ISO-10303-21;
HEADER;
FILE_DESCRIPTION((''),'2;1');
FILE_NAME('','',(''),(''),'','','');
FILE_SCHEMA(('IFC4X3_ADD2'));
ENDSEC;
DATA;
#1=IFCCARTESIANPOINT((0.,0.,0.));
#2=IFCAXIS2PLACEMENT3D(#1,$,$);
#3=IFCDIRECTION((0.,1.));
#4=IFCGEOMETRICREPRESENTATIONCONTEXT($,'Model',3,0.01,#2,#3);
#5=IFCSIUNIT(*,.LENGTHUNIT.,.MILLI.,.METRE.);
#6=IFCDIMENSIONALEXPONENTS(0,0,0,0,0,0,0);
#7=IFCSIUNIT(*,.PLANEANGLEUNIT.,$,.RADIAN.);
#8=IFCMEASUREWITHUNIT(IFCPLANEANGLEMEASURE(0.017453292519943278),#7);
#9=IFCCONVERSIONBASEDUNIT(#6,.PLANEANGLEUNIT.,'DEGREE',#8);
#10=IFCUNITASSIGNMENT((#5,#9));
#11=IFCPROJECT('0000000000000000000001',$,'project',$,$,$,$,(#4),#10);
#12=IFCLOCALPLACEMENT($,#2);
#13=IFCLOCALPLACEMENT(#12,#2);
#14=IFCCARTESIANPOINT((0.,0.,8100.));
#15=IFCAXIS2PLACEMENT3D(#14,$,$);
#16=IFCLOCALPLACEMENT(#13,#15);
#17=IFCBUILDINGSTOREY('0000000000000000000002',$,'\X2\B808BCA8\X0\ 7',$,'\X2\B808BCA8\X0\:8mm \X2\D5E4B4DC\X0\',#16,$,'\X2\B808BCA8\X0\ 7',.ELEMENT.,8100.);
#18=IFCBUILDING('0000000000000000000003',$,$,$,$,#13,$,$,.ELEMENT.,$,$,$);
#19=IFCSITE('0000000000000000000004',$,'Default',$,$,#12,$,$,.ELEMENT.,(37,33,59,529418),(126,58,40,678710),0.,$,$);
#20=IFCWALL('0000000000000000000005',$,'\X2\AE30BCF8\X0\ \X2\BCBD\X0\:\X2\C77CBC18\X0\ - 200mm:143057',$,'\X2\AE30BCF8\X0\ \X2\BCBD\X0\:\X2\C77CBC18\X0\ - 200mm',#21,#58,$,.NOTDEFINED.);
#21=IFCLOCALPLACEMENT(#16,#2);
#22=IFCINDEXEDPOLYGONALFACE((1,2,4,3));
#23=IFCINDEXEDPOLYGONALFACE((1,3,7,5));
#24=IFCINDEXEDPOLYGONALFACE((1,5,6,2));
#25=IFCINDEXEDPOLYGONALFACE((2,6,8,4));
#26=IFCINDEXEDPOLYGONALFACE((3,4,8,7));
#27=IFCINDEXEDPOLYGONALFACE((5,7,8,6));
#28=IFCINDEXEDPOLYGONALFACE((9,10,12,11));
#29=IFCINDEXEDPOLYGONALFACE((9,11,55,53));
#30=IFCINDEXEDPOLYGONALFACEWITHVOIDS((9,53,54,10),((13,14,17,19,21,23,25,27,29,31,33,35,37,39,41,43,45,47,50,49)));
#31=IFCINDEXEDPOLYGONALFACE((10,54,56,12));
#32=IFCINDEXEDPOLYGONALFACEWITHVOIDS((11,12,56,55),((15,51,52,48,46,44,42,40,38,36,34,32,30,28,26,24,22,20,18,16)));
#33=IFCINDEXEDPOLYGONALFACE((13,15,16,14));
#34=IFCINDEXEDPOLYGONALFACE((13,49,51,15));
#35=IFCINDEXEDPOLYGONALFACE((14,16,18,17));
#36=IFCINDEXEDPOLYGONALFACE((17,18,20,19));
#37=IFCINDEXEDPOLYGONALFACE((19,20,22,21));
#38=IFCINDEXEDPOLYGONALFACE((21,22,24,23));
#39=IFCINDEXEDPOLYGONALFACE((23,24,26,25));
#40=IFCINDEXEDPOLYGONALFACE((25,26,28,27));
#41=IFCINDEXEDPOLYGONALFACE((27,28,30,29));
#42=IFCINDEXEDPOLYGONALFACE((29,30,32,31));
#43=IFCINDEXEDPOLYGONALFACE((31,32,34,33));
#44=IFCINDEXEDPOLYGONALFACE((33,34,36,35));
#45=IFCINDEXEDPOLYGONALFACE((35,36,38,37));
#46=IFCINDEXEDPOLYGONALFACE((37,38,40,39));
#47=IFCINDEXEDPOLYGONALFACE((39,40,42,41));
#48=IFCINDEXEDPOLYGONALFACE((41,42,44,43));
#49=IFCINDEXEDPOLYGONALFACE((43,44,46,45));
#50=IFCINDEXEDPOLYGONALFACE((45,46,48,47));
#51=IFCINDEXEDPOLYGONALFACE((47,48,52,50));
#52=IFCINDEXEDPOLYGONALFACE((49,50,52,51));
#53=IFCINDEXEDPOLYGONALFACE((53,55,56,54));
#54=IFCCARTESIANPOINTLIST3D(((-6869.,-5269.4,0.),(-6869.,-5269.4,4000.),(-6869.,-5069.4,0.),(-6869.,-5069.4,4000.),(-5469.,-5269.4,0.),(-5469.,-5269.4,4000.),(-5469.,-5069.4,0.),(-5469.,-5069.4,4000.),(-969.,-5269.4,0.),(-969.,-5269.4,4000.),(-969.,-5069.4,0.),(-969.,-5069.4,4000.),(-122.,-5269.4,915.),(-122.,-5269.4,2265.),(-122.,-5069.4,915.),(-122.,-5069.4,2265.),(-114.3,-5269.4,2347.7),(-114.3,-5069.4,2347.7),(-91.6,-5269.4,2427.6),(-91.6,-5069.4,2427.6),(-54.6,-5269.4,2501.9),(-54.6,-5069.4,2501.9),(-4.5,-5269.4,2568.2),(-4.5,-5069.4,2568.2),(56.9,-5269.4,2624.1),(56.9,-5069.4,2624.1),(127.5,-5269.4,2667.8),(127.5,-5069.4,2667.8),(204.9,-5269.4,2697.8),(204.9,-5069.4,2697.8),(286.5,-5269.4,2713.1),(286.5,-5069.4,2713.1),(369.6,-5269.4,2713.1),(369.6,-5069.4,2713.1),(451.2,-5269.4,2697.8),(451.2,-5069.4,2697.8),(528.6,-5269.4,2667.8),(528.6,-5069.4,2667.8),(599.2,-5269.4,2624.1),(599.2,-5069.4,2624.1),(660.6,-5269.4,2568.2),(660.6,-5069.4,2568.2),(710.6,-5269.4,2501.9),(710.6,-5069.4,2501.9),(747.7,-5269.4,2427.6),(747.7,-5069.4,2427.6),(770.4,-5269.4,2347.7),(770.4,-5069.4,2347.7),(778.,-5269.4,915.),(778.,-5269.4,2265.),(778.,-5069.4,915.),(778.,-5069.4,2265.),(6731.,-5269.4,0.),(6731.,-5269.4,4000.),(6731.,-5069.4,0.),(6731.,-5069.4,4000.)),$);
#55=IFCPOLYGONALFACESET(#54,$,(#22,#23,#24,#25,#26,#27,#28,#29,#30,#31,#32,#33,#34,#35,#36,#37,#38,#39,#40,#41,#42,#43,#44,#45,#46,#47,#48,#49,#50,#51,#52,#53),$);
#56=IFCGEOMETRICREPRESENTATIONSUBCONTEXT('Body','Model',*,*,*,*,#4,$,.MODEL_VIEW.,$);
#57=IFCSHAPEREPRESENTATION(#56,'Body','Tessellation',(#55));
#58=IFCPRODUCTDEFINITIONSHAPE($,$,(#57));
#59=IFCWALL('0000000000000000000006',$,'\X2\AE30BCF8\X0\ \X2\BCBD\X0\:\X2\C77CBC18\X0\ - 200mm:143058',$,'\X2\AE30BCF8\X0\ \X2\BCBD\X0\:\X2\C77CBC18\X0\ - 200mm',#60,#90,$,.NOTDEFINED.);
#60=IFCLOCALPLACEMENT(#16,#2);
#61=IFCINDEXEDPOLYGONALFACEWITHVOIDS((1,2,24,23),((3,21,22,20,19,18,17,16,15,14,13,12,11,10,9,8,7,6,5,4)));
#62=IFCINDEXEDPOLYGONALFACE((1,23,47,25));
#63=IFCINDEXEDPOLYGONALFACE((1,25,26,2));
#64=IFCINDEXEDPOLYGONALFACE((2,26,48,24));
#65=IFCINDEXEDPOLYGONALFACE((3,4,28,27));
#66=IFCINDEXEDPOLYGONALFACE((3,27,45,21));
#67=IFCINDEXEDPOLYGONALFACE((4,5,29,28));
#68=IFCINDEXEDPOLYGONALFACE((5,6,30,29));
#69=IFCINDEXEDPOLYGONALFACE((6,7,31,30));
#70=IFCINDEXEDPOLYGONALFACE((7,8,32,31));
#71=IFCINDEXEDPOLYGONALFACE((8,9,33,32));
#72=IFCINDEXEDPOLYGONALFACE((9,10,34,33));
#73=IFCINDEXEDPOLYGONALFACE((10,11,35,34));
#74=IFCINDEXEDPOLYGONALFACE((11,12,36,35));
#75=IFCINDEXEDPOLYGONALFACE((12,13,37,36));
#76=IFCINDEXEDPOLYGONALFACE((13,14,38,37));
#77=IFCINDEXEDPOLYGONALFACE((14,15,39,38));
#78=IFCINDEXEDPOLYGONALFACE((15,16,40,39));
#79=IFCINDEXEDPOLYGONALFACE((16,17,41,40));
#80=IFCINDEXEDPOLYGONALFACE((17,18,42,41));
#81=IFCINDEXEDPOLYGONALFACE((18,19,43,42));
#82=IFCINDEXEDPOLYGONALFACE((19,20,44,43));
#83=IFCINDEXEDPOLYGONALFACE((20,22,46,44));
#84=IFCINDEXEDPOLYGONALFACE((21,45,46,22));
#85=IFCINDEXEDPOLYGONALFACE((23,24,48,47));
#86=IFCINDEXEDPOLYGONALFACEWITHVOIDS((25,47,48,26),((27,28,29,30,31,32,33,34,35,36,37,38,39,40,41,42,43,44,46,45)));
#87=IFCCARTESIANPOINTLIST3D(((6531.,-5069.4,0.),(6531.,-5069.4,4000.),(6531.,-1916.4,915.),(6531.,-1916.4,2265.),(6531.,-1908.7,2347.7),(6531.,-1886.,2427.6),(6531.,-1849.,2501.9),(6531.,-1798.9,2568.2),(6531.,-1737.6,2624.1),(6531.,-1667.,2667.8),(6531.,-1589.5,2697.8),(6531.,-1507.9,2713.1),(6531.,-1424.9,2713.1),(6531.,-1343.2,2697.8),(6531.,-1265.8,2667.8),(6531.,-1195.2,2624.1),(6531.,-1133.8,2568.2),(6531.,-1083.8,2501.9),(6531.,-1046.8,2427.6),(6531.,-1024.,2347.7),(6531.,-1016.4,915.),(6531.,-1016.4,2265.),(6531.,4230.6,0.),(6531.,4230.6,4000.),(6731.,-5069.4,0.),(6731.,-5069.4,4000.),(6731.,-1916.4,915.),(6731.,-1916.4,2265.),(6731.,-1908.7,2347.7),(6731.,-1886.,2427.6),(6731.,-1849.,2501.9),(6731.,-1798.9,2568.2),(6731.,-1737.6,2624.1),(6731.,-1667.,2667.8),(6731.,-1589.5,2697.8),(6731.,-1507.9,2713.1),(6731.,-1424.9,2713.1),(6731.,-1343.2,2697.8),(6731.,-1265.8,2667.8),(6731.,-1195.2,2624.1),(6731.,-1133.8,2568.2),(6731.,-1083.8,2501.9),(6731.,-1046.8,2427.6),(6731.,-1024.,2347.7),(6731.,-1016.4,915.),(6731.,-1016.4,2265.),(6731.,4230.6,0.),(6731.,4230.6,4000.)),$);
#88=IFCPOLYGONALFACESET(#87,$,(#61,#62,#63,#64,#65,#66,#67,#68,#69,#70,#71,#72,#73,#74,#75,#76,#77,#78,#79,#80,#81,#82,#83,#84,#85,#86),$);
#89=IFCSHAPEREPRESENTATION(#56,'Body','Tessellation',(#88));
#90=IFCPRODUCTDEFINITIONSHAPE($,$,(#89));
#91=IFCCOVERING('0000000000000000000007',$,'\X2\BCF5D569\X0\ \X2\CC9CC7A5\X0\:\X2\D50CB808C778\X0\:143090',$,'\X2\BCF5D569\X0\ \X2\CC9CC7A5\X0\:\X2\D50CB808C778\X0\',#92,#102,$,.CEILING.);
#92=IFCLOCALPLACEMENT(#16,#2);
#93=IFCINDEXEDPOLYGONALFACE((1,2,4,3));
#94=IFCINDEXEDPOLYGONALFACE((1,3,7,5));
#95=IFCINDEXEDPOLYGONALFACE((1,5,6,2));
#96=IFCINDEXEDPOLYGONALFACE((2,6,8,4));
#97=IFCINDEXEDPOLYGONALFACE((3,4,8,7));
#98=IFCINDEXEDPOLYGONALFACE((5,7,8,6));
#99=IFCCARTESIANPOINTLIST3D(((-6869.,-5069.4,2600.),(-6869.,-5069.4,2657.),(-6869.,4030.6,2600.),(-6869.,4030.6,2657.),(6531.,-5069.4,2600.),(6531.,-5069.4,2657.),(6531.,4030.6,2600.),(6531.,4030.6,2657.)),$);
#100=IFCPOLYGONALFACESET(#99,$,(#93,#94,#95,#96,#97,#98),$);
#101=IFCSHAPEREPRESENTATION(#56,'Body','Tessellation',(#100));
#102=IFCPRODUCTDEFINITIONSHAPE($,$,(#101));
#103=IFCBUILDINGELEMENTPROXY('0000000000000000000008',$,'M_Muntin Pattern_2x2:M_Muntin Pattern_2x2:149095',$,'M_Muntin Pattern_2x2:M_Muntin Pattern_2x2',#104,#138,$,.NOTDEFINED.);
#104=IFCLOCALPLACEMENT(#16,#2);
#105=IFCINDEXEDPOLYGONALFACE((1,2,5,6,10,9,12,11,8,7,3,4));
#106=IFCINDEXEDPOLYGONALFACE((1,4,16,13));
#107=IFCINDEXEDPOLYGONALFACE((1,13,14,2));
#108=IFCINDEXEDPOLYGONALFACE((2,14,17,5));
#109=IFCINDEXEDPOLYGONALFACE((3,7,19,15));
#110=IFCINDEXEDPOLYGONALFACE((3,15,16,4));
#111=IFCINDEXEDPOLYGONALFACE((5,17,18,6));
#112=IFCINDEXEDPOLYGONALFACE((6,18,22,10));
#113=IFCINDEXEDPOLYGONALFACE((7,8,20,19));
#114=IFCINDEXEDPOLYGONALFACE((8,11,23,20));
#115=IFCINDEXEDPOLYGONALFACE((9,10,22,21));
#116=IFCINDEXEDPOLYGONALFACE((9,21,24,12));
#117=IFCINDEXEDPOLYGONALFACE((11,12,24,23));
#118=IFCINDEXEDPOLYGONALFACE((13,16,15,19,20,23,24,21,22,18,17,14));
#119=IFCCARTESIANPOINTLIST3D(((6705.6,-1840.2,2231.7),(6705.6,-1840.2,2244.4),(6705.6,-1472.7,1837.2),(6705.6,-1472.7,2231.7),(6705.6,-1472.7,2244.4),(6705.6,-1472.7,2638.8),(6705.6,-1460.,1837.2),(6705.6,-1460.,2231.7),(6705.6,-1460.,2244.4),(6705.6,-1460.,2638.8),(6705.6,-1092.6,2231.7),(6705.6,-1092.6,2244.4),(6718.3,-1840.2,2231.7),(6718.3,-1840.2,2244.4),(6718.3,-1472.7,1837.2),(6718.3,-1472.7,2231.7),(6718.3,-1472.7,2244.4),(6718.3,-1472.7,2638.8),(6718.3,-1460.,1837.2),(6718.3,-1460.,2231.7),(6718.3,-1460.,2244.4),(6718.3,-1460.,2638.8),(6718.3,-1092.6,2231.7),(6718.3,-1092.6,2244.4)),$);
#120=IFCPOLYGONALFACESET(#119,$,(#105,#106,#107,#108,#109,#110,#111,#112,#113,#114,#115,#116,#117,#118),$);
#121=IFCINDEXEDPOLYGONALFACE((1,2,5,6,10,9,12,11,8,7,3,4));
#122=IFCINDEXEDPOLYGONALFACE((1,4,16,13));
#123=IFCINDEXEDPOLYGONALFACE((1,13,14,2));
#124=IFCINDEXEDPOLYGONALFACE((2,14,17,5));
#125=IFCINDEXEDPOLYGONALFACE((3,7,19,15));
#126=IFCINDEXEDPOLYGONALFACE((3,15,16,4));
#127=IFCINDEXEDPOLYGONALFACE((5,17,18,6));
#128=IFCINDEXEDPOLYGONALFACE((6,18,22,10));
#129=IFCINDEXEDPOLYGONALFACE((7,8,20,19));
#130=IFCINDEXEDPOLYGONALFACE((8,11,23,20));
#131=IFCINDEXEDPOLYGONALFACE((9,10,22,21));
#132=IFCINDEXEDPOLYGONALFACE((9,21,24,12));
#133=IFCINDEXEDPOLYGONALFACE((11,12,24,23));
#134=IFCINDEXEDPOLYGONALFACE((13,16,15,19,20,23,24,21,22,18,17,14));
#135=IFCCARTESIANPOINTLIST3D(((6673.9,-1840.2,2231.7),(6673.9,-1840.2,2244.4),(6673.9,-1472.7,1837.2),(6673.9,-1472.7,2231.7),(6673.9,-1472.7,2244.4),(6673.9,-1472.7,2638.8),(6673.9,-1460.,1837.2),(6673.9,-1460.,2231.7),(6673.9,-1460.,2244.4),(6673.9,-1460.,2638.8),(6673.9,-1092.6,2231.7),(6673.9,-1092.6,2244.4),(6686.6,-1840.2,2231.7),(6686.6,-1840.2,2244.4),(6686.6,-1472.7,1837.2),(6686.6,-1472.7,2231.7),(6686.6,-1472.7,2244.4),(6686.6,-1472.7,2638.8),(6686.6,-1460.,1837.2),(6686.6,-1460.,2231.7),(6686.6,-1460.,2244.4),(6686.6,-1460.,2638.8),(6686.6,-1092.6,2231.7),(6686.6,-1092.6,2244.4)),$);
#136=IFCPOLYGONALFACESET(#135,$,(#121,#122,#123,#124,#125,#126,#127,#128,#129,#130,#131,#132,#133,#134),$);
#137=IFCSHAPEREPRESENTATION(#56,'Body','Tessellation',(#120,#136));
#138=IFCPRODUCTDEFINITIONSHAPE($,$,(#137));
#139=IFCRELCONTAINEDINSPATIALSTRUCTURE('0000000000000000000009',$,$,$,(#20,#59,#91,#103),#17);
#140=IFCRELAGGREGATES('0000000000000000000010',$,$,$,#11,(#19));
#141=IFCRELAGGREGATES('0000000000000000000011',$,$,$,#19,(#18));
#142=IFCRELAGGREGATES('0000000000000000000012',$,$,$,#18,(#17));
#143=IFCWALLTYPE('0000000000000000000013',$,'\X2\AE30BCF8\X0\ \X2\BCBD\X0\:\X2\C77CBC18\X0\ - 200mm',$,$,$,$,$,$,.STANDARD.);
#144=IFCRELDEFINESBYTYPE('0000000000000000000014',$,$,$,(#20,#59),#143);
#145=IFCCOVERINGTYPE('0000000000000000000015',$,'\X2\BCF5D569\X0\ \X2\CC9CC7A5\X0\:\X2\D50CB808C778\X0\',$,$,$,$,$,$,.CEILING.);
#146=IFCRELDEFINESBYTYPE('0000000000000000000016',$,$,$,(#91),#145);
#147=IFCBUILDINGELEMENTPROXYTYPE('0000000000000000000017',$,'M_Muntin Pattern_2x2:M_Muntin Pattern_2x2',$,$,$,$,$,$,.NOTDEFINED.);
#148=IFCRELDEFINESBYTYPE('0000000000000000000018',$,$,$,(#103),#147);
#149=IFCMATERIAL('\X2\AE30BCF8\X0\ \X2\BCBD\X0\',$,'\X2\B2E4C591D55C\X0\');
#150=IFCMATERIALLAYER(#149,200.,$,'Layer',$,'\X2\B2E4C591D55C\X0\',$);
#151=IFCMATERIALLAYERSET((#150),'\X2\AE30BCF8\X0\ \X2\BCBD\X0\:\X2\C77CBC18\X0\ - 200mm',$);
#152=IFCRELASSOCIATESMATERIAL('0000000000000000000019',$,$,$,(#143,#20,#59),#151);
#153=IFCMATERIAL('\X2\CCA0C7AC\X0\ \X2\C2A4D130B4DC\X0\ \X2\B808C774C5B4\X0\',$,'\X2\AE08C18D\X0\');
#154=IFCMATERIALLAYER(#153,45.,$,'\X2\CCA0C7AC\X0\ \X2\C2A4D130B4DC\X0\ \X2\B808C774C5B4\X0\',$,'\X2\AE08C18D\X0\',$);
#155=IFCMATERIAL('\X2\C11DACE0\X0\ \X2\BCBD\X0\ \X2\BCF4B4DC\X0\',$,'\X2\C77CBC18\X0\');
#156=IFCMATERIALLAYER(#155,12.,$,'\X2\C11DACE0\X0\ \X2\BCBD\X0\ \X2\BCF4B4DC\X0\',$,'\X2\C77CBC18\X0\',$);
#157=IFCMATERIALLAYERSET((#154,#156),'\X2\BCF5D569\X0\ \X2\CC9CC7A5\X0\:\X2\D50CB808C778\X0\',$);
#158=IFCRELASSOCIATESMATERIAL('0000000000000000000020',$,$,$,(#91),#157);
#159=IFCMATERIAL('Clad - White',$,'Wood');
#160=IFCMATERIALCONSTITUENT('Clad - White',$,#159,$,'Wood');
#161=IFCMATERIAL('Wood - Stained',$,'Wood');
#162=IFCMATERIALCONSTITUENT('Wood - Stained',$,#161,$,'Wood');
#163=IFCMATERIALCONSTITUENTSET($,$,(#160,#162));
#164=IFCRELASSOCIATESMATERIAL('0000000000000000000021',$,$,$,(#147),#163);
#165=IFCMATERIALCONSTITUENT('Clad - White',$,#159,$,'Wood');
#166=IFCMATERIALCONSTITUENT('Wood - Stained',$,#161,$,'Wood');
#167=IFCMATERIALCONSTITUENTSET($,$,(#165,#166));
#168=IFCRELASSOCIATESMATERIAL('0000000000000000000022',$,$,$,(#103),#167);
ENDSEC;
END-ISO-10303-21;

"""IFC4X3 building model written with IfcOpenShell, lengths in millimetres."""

from ifc_helpers import new_model, entity, si_unit, converted_unit, direction, frame, frame_2d, origin, origin_2d_with_axis, place, context, subcontext, project, spatial, polyline, circle_curve, parameter, trimmed, segment, composite_curve, rectangle, outline, extrude, source, transform, mapped, material, layer, layer_set, layer_usage, constituent, constituent_set, type_object, type_shapes, element, save


model = new_model("IFC4X3")

# Units and contexts
model_context = context("Model", 3, precision=0.01, world=origin(), true_north=direction((0.0, 1.0)))
body_context = subcontext(model_context, "Body", "Model", "MODEL_VIEW")
ifc_project = project(units=[si_unit("LENGTHUNIT", "METRE", prefix="MILLI"), converted_unit("PLANEANGLEUNIT", "DEGREE", entity("IfcPlaneAngleMeasure", 0.017453292519943278), si_unit("PLANEANGLEUNIT", "RADIAN"), dimensions=[0, 0, 0, 0, 0, 0, 0])], contexts=[model_context])

# Site, building, storey
site_placement = place(None, origin())
site = spatial("IfcSite", under=ifc_project, at=site_placement, Name="Default", CompositionType="ELEMENT", RefLatitude=(37, 33, 59, 529418), RefLongitude=(126, 58, 40, 678710), RefElevation=0.0)
building_placement = place(site_placement, origin())
building = spatial("IfcBuilding", under=site, at=building_placement, CompositionType="ELEMENT")
storey_placement = place(building_placement, frame((0.0, 0.0, 8100.0)))
storey = spatial("IfcBuildingStorey", under=building, at=storey_placement, Name="레벨 7", ObjectType="레벨:8mm 헤드", LongName="레벨 7", CompositionType="ELEMENT", Elevation=8100.0)

# Shared definitions
ifc_material_1 = material(Name="기본 벽", Category="다양한")
ifc_layer_1 = layer(ifc_material_1, 200.0, Name="Layer", Category="다양한")
ifc_layer_set_1 = layer_set([ifc_layer_1], Name="기본 벽:일반 - 200mm")
wall_type = type_object("IfcWallType", Name="기본 벽:일반 - 200mm", PredefinedType="STANDARD", material=ifc_layer_set_1)

# Wall, openings
wall_1_placement = place(storey_placement, frame((6731.0, -5169.4, 0.0), z_axis=(0.0, 0.0, 1.0), x_axis=(-1.0, 0.0, 0.0)))
wall_1 = element("IfcWall", 1, at=wall_1_placement, inside=storey, type_object=wall_type, material=ifc_layer_set_1, Name="기본 벽:일반 - 200mm:143057", ObjectType="기본 벽:일반 - 200mm", PredefinedType="NOTDEFINED", context=body_context, shape_type="SweptSolid", body=[
    extrude(rectangle(XDim=200.0, YDim=13600.0, at=frame_2d((6800.0, 0.0), x_axis=(0.0, -1.0))), origin(), (0.0, 0.0, 1.0), 4000.0),
])
opening_1_placement = place(wall_1_placement, frame((12200.0, 252.4, -8100.0)))
element("IfcOpeningElement", 2, at=opening_1_placement, cuts=wall_1, PredefinedType="OPENING", context=body_context, shape_type="SweptSolid", body=[
    extrude(rectangle(XDim=14356.3, YDim=4500.0, at=frame_2d((0.0, 0.0), x_axis=(0.0, 1.0))), frame((-2250.0, -504.8, 7178.2), z_axis=(0.0, 1.0, 0.0), x_axis=(-1.0, 0.0, 0.0)), (0.0, 0.0, 1.0), 504.8),
])
opening_2_placement = place(wall_1_placement, frame((5953.0, -100.0, 915.0)))
element("IfcOpeningElement", 3, at=opening_2_placement, cuts=wall_1, PredefinedType="OPENING", context=body_context, shape_type="SweptSolid", body=[
    extrude(outline(composite_curve([segment(polyline([(1350.0, 900.0), (0.0, 900.0)]), True, "CONTINUOUS"), segment(polyline([(0.0, 900.0), (0.0, 0.0)]), True, "CONTINUOUS"), segment(polyline([(0.0, 0.0), (1350.0, 0.0)]), True, "CONTINUOUS"), segment(trimmed(circle_curve(frame_2d((1350.0, 450.0), x_axis=(0.0, 1.0)), 450.0), [parameter(180.0)], [parameter(0.0)], True, "PARAMETER"), True, "CONTINUOUS")], self_intersect=False)), frame((0.0, 0.0, 0.0), z_axis=(0.0, 1.0, 0.0), x_axis=(0.0, 0.0, 1.0)), (0.0, 0.0, 1.0), 200.0),
])

# Wall, opening
wall_2_placement = place(storey_placement, frame((6631.0, 4230.6, 0.0), z_axis=(0.0, 0.0, 1.0), x_axis=(0.0, -1.0, 0.0)))
wall_2 = element("IfcWall", 4, at=wall_2_placement, inside=storey, type_object=wall_type, material=ifc_layer_set_1, Name="기본 벽:일반 - 200mm:143058", ObjectType="기본 벽:일반 - 200mm", PredefinedType="NOTDEFINED", context=body_context, shape_type="SweptSolid", body=[
    extrude(rectangle(XDim=9300.0, YDim=200.0, at=frame_2d((4650.0, 0.0), x_axis=(-1.0, 0.0))), origin(), (0.0, 0.0, 1.0), 4000.0),
])
opening_3_placement = place(wall_2_placement, frame((5247.0, -100.0, 915.0)))
element("IfcOpeningElement", 5, at=opening_3_placement, cuts=wall_2, PredefinedType="OPENING", context=body_context, shape_type="SweptSolid", body=[
    extrude(outline(composite_curve([segment(polyline([(1350.0, 900.0), (0.0, 900.0)]), True, "CONTINUOUS"), segment(polyline([(0.0, 900.0), (0.0, 0.0)]), True, "CONTINUOUS"), segment(polyline([(0.0, 0.0), (1350.0, 0.0)]), True, "CONTINUOUS"), segment(trimmed(circle_curve(frame_2d((1350.0, 450.0), x_axis=(0.0, 1.0)), 450.0), [parameter(180.0)], [parameter(0.0)], True, "PARAMETER"), True, "CONTINUOUS")], self_intersect=False)), frame((0.0, 0.0, 0.0), z_axis=(0.0, 1.0, 0.0), x_axis=(0.0, 0.0, 1.0)), (0.0, 0.0, 1.0), 200.0),
])

# Covering
ifc_material_2 = material(Name="철재 스터드 레이어", Category="금속")
ifc_layer_2 = layer(ifc_material_2, 45.0, Name="철재 스터드 레이어", Category="금속")
ifc_material_3 = material(Name="석고 벽 보드", Category="일반")
ifc_layer_3 = layer(ifc_material_3, 12.0, Name="석고 벽 보드", Category="일반")
ifc_layer_set_2 = layer_set([ifc_layer_2, ifc_layer_3], Name="복합 천장:플레인")
ifc_layer_usage_1 = layer_usage(ifc_layer_set_2, "AXIS3", "NEGATIVE", 0.0)
covering_type = type_object("IfcCoveringType", Name="복합 천장:플레인", PredefinedType="CEILING")
covering_placement = place(storey_placement, frame((-6869.0, -5069.4, 2600.0)))
element("IfcCovering", 6, at=covering_placement, inside=storey, type_object=covering_type, material=ifc_layer_usage_1, Name="복합 천장:플레인:143090", ObjectType="복합 천장:플레인", PredefinedType="CEILING", context=body_context, shape_type="SweptSolid", body=[
    extrude(rectangle(XDim=9100.0, YDim=13400.0, at=origin_2d_with_axis()), frame((6700.0, 4550.0, 0.0), z_axis=(0.0, 0.0, 1.0), x_axis=(0.0, -1.0, 0.0)), (0.0, 0.0, 1.0), 57.0),
])

# Building element proxy
ifc_material_4 = material(Name="Clad - White", Category="Wood")
ifc_constituent_1 = constituent(ifc_material_4, Name="Clad - White", Category="Wood")
ifc_material_5 = material(Name="Wood - Stained", Category="Wood")
ifc_constituent_2 = constituent(ifc_material_5, Name="Wood - Stained", Category="Wood")
ifc_constituent_set_1 = constituent_set(constituents=[ifc_constituent_1, ifc_constituent_2])
ifc_constituent_3 = constituent(ifc_material_4, Name="Clad - White", Category="Wood")
ifc_constituent_4 = constituent(ifc_material_5, Name="Wood - Stained", Category="Wood")
ifc_constituent_set_2 = constituent_set(constituents=[ifc_constituent_3, ifc_constituent_4])
building_element_proxy_type_1 = type_object("IfcBuildingElementProxyType", Name="M_Muntin Pattern_2x2:M_Muntin Pattern_2x2", PredefinedType="NOTDEFINED", material=ifc_constituent_set_2)
shared_shape_1 = source(origin(), body_context, "Body", "SweptSolid", [
    extrude(outline(polyline([(6.4, -6.4), (400.8, -6.4), (400.8, 6.3), (6.4, 6.3), (6.4, 373.8), (-6.3, 373.8), (-6.3, 6.3), (-400.8, 6.3), (-400.8, -6.4), (-6.3, -6.4), (-6.3, -373.8), (6.4, -373.8), (6.4, -6.4)])), frame((0.0, 9.5, 400.8), z_axis=(0.0, 1.0, 0.0), x_axis=(0.0, 0.0, 1.0)), (0.0, 0.0, 1.0), 12.7),
    extrude(outline(polyline([(6.4, -6.4), (400.8, -6.4), (400.8, 6.3), (6.4, 6.3), (6.4, 373.8), (-6.3, 373.8), (-6.3, 6.3), (-400.8, 6.3), (-400.8, -6.4), (-6.3, -6.4), (-6.3, -373.8), (6.4, -373.8), (6.4, -6.4)])), frame((0.0, -22.2, 400.8), z_axis=(0.0, 1.0, 0.0), x_axis=(0.0, 0.0, 1.0)), (0.0, 0.0, 1.0), 12.7),
])
type_shapes(building_element_proxy_type_1, [shared_shape_1])
proxy_1_placement = place(storey_placement, frame((6696.1, -1466.4, 1837.2), z_axis=(0.0, 0.0, 1.0), x_axis=(0.0, -1.0, 0.0)))
element("IfcBuildingElementProxy", 7, at=proxy_1_placement, inside=storey, type_object=building_element_proxy_type_1, material=ifc_constituent_set_1, Name="M_Muntin Pattern_2x2:M_Muntin Pattern_2x2:149095", ObjectType="M_Muntin Pattern_2x2:M_Muntin Pattern_2x2", PredefinedType="NOTDEFINED", context=body_context, shape_type="MappedRepresentation", body=[
    mapped(shared_shape_1, transform((0.0, 0.0, 0.0), scale=1.0)),
])

save(model, "model.ifc")
